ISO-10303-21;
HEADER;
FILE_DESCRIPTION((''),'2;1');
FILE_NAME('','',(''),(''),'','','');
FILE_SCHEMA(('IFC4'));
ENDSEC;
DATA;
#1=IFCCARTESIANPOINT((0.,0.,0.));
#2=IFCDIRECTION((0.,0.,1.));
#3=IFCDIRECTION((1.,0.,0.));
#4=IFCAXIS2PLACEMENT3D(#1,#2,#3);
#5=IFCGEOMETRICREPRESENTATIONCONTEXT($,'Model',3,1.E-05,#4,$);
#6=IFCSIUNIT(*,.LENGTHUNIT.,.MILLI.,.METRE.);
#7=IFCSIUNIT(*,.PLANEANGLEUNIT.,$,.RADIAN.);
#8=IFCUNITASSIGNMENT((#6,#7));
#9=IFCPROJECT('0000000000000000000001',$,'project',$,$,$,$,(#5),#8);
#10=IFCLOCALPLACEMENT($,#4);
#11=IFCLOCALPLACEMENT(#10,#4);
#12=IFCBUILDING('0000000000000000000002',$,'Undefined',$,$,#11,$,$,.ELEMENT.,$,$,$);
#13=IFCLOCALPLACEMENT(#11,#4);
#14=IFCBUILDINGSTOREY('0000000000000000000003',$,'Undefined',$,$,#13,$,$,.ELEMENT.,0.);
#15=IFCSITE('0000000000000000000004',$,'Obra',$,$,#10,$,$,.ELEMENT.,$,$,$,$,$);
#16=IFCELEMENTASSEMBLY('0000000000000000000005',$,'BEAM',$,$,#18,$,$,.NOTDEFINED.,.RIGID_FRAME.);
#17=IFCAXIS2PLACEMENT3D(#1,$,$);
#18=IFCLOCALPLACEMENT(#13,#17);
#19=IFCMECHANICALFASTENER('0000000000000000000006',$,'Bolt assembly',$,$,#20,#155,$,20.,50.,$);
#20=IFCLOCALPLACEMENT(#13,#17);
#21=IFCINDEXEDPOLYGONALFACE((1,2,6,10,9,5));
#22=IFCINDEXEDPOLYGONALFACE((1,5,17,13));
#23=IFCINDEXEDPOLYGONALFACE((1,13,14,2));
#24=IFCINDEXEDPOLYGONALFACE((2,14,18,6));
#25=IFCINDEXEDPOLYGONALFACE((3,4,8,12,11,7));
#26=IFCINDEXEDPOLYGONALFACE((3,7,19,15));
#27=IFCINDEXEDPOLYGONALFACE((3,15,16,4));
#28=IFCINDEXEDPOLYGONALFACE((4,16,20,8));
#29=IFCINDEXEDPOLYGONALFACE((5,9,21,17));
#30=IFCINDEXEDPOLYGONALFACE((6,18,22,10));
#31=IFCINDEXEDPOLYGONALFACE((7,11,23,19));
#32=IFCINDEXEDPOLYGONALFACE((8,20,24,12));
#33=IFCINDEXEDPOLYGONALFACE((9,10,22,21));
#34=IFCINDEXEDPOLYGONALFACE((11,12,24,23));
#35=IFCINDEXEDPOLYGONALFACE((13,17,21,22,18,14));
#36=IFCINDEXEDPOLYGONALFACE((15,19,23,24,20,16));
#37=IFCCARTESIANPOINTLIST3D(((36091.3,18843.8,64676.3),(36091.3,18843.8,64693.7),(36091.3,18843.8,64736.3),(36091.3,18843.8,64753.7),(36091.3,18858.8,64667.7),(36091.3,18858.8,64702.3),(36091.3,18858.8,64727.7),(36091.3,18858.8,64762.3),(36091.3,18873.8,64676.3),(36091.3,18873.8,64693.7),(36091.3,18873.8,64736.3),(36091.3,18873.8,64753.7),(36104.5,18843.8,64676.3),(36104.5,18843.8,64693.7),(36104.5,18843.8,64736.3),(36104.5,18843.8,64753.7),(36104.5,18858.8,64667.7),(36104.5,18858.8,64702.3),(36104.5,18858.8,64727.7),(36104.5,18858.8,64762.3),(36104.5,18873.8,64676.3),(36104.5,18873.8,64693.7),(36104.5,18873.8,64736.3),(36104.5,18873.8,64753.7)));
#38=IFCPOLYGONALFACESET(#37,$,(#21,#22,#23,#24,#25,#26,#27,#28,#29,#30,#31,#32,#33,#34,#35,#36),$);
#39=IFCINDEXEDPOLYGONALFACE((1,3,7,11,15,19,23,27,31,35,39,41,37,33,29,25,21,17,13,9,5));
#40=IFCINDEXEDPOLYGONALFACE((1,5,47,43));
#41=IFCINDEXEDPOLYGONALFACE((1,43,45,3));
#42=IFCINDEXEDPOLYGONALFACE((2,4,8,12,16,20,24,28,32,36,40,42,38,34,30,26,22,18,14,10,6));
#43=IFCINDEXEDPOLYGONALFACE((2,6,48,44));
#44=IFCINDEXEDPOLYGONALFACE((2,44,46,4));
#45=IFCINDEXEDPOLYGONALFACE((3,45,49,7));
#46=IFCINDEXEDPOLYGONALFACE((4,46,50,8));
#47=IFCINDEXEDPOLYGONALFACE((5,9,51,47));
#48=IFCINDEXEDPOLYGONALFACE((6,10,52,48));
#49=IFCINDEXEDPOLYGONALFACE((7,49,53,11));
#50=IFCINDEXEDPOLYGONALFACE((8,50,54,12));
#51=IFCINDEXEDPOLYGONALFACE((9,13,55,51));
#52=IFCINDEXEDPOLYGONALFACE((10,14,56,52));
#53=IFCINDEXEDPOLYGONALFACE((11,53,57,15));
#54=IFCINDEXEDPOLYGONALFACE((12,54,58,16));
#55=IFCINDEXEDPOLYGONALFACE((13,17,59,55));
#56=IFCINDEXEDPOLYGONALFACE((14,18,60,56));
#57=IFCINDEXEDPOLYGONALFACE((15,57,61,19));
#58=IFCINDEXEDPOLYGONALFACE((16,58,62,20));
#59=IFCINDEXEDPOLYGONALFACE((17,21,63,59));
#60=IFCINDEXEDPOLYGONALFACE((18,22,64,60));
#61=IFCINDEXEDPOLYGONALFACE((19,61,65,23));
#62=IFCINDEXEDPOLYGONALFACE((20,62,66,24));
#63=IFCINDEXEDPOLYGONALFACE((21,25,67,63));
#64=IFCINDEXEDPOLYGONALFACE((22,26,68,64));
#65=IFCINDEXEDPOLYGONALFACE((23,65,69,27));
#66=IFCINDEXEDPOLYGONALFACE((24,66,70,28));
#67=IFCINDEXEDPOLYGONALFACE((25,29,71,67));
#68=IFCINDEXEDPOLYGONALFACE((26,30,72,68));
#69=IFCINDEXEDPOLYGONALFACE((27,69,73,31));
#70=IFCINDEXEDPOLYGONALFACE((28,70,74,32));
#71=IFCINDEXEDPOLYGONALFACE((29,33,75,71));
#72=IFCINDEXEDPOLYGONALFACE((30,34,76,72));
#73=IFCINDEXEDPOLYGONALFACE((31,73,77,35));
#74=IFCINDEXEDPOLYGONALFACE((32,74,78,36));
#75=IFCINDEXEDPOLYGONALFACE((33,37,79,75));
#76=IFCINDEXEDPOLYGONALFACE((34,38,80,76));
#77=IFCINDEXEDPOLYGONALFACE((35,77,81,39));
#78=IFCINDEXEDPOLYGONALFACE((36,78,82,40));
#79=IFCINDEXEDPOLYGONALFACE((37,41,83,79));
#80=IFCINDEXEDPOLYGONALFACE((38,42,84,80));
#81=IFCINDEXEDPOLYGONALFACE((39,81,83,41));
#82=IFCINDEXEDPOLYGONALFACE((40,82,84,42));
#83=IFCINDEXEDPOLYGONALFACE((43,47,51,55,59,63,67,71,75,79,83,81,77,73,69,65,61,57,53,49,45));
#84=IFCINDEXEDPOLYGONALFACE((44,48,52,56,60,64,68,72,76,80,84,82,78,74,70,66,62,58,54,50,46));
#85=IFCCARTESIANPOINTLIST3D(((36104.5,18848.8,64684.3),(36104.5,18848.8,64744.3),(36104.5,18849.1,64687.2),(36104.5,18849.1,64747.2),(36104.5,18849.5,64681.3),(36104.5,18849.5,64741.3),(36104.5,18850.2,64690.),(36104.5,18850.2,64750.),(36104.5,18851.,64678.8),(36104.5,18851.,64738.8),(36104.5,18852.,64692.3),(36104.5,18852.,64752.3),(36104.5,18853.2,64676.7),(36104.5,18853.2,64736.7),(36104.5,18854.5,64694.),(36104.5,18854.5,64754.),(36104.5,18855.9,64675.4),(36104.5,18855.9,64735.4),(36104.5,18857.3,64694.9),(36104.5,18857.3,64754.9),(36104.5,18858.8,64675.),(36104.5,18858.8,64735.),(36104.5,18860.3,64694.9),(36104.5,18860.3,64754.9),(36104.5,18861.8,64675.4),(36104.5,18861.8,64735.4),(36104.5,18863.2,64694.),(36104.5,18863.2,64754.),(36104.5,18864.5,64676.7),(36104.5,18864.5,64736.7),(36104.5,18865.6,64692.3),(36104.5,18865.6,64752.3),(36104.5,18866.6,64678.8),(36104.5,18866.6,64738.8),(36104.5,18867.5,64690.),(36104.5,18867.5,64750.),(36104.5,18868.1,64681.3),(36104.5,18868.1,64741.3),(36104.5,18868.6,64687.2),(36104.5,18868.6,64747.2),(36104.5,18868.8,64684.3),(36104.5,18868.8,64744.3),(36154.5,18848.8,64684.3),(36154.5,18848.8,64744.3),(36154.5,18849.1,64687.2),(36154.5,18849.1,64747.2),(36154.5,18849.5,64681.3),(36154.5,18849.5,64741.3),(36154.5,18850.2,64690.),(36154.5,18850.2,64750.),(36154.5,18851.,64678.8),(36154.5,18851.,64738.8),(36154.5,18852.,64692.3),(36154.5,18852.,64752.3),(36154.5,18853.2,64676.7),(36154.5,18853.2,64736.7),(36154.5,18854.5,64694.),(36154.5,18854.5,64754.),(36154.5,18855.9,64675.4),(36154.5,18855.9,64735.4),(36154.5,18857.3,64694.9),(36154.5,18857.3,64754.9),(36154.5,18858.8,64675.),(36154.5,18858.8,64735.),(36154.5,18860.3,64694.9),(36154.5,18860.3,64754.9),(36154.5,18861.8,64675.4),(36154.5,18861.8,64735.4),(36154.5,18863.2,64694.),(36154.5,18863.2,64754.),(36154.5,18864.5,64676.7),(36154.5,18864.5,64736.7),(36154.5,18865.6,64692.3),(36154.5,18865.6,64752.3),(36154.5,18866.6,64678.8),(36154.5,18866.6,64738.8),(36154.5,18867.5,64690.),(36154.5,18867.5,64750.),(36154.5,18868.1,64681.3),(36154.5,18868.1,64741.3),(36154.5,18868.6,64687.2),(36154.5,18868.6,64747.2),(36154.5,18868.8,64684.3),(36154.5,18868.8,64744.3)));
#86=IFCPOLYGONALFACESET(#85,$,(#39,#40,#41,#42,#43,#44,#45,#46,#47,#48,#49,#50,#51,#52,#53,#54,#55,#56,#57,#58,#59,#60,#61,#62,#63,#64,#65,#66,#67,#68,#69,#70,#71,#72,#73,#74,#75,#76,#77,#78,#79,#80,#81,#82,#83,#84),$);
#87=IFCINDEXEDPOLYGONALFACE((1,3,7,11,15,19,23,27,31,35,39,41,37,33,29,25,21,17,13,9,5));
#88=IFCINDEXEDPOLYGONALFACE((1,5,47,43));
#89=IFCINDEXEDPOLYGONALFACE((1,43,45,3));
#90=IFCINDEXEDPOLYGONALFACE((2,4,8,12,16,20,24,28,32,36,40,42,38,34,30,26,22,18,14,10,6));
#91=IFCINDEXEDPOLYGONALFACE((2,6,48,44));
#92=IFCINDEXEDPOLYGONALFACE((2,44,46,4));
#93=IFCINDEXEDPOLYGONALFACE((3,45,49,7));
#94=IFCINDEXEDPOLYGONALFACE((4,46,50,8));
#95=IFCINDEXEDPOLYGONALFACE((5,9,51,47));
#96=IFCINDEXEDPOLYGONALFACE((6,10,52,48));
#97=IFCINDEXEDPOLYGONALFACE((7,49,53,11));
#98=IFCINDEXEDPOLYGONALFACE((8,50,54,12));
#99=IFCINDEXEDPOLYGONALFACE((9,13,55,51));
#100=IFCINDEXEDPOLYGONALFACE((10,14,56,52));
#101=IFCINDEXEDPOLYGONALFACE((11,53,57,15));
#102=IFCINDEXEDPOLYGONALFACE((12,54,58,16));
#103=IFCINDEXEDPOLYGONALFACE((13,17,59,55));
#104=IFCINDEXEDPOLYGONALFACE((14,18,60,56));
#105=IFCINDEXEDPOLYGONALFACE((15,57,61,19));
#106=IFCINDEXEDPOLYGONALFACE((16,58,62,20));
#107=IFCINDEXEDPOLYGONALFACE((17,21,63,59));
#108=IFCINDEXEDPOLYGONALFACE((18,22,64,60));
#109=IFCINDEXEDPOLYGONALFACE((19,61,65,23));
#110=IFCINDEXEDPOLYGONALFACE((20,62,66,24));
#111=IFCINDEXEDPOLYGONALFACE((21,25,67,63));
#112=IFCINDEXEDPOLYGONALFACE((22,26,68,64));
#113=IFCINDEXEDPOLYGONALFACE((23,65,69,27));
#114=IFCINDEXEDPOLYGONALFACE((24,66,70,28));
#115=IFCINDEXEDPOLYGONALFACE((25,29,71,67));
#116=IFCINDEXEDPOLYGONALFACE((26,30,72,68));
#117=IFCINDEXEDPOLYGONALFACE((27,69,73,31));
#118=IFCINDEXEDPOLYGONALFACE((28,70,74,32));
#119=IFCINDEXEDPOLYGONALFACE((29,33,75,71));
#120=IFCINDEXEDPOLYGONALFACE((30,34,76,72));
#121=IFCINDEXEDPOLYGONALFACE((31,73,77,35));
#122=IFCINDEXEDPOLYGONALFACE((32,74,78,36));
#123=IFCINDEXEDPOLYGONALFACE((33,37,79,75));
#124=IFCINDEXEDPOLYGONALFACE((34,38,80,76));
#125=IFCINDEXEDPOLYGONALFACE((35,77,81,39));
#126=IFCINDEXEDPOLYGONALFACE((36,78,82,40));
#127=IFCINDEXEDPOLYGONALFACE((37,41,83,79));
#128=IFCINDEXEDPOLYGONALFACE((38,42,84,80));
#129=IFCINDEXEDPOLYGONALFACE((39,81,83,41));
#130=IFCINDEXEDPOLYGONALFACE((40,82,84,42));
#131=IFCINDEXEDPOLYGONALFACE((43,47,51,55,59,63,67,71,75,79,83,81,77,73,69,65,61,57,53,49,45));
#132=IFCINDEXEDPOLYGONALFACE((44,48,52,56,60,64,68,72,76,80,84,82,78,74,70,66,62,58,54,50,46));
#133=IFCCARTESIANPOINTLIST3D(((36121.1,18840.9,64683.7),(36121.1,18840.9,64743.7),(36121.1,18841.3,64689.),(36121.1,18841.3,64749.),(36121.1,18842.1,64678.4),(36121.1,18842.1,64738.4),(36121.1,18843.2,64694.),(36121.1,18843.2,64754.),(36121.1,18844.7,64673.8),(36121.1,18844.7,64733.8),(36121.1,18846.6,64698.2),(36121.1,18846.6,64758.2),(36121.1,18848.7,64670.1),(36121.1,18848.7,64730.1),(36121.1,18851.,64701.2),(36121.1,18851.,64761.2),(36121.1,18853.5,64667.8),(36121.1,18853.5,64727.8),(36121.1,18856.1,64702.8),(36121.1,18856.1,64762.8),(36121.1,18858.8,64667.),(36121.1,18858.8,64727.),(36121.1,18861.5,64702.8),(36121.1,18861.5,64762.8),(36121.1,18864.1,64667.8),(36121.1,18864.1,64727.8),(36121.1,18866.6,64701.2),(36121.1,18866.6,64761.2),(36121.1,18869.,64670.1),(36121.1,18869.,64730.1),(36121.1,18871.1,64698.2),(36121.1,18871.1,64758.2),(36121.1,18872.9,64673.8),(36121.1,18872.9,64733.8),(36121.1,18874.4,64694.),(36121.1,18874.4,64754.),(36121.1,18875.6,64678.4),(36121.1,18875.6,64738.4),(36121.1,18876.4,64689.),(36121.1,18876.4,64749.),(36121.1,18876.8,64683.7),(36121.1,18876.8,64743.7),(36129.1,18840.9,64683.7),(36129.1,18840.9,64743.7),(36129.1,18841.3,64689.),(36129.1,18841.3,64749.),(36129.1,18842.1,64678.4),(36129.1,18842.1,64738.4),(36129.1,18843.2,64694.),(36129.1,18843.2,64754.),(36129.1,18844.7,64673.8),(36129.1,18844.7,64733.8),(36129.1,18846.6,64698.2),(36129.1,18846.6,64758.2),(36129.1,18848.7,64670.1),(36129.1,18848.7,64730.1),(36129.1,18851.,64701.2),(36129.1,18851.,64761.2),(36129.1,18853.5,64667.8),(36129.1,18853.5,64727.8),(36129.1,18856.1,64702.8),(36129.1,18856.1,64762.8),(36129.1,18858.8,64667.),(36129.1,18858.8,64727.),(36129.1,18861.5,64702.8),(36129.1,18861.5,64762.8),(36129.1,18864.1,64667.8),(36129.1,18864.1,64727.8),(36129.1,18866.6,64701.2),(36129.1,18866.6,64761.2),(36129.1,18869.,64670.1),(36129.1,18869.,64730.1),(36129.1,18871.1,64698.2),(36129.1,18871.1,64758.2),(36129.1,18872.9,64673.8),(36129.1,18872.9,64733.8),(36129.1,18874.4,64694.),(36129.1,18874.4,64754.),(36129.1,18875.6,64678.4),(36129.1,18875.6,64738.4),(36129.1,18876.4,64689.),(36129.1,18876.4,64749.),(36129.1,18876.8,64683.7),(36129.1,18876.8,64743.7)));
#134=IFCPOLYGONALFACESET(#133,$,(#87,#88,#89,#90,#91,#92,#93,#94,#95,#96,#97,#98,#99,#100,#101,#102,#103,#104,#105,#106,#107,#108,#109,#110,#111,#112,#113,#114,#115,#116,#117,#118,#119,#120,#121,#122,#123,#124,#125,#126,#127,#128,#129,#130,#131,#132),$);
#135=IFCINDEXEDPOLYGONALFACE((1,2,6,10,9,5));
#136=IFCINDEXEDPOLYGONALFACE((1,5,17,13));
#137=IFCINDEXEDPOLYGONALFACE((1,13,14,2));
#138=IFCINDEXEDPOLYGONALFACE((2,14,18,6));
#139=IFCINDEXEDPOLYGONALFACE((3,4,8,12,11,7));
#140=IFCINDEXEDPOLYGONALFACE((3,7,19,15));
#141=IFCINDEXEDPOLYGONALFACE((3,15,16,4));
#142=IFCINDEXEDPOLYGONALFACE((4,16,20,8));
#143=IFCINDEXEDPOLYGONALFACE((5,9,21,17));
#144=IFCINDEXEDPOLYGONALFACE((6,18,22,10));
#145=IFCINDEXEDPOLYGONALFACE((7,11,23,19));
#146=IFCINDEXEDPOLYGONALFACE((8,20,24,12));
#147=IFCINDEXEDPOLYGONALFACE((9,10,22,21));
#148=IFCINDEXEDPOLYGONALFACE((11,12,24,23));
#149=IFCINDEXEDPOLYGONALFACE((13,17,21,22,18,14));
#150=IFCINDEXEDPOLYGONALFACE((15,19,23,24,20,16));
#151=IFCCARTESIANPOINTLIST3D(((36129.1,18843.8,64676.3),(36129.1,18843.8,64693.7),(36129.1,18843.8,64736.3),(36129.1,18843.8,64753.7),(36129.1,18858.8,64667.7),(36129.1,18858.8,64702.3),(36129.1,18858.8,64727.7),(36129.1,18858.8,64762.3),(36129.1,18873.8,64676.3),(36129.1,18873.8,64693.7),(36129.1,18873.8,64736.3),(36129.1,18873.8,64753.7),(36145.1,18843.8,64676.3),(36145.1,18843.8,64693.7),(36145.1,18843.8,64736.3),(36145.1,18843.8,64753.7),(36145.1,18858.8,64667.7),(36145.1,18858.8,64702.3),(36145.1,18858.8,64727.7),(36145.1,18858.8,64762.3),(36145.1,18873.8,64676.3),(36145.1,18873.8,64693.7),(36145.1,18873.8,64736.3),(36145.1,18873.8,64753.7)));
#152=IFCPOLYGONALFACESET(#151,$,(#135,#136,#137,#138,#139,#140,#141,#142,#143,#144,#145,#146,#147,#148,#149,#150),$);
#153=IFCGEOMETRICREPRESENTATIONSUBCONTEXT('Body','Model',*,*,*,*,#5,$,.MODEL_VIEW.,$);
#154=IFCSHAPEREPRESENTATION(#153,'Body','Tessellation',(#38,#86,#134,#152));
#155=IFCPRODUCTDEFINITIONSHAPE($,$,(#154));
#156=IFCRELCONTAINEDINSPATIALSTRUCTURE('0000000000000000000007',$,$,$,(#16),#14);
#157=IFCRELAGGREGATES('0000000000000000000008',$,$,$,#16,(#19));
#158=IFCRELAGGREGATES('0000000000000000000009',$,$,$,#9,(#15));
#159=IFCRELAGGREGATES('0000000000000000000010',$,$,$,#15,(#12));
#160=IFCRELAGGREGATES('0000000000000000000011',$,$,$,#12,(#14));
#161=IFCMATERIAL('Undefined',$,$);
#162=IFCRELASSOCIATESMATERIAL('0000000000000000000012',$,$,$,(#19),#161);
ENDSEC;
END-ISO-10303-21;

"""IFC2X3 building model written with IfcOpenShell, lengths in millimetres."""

from ifc_helpers import new_model, si_unit, frame, origin_with_axes, origin_2d_with_axis, place, context, subcontext, project, spatial, polyline, circle, outline, extrude, source, transform, mapped, material, element, aggregate, save


model = new_model("IFC2X3")

# Units and contexts
model_context = context("Model", 3, precision=1e-05, world=origin_with_axes())
body_context = subcontext(model_context, "Body", "Model", "MODEL_VIEW")
ifc_project = project(units=[si_unit("LENGTHUNIT", "METRE", prefix="MILLI"), si_unit("PLANEANGLEUNIT", "RADIAN")], contexts=[model_context])

# Site, building, storey
site_placement = place(None, origin_with_axes())
site = spatial("IfcSite", under=ifc_project, at=site_placement, Name="Obra", CompositionType="ELEMENT")
building_placement = place(site_placement, origin_with_axes())
building = spatial("IfcBuilding", under=site, at=building_placement, Name="Undefined", CompositionType="ELEMENT")
storey_placement = place(building_placement, origin_with_axes())
storey = spatial("IfcBuildingStorey", under=building, at=storey_placement, Name="Undefined", CompositionType="ELEMENT", Elevation=0.0)

# Shared definitions
ifc_material = material(Name="Undefined")
shared_shape_1 = source(origin_with_axes(), body_context, "Body", "SweptSolid", [
    extrude(outline(polyline([(17.3, 0.0), (8.7, 15.0), (-8.7, 15.0), (-17.3, 0.0), (-8.7, -15.0), (8.7, -15.0), (17.3, 0.0)])), frame((0.0, -26.5, 0.0), z_axis=(0.0, 1.0, 0.0), x_axis=(1.0, 0.0, 0.0)), (0.0, 0.0, 1.0), 13.2),
    extrude(circle(Radius=10.0, at=origin_2d_with_axis()), frame((0.0, -13.3, 0.0), z_axis=(0.0, 1.0, 0.0), x_axis=(1.0, 0.0, 0.0)), (0.0, 0.0, 1.0), 50.0),
    extrude(circle(Radius=18.0, at=origin_2d_with_axis()), frame((0.0, 3.3, 0.0), z_axis=(0.0, 1.0, 0.0), x_axis=(1.0, 0.0, 0.0)), (0.0, 0.0, 1.0), 8.0),
    extrude(outline(polyline([(17.3, 0.0), (8.7, 15.0), (-8.7, 15.0), (-17.3, 0.0), (-8.7, -15.0), (8.7, -15.0), (17.3, 0.0)])), frame((0.0, 11.3, 0.0), z_axis=(0.0, 1.0, 0.0), x_axis=(1.0, 0.0, 0.0)), (0.0, 0.0, 1.0), 16.0),
])

# Element assembly, mechanical fastener
assembly_1_placement = place(storey_placement, origin_with_axes())
assembly_1 = element("IfcElementAssembly", 1, at=assembly_1_placement, inside=storey, Name="BEAM", AssemblyPlace="NOTDEFINED", PredefinedType="RIGID_FRAME")
mechanical_fastener_1_placement = place(assembly_1_placement, frame((36117.8, 18898.8, 64850.0), z_axis=(0.0, -1.0, 0.0), x_axis=(0.0, 0.0, -1.0)))
mechanical_fastener_1 = element("IfcMechanicalFastener", 2, at=mechanical_fastener_1_placement, material=ifc_material, Name="Bolt assembly", NominalDiameter=20.0, NominalLength=50.0, context=body_context, shape_type="MappedRepresentation", body=[
    mapped(shared_shape_1, transform((105.0, 0.0, 40.0))),
    mapped(shared_shape_1, transform((165.0, 0.0, 40.0))),
])
aggregate(assembly_1, [mechanical_fastener_1])

save(model, "model.ifc")
